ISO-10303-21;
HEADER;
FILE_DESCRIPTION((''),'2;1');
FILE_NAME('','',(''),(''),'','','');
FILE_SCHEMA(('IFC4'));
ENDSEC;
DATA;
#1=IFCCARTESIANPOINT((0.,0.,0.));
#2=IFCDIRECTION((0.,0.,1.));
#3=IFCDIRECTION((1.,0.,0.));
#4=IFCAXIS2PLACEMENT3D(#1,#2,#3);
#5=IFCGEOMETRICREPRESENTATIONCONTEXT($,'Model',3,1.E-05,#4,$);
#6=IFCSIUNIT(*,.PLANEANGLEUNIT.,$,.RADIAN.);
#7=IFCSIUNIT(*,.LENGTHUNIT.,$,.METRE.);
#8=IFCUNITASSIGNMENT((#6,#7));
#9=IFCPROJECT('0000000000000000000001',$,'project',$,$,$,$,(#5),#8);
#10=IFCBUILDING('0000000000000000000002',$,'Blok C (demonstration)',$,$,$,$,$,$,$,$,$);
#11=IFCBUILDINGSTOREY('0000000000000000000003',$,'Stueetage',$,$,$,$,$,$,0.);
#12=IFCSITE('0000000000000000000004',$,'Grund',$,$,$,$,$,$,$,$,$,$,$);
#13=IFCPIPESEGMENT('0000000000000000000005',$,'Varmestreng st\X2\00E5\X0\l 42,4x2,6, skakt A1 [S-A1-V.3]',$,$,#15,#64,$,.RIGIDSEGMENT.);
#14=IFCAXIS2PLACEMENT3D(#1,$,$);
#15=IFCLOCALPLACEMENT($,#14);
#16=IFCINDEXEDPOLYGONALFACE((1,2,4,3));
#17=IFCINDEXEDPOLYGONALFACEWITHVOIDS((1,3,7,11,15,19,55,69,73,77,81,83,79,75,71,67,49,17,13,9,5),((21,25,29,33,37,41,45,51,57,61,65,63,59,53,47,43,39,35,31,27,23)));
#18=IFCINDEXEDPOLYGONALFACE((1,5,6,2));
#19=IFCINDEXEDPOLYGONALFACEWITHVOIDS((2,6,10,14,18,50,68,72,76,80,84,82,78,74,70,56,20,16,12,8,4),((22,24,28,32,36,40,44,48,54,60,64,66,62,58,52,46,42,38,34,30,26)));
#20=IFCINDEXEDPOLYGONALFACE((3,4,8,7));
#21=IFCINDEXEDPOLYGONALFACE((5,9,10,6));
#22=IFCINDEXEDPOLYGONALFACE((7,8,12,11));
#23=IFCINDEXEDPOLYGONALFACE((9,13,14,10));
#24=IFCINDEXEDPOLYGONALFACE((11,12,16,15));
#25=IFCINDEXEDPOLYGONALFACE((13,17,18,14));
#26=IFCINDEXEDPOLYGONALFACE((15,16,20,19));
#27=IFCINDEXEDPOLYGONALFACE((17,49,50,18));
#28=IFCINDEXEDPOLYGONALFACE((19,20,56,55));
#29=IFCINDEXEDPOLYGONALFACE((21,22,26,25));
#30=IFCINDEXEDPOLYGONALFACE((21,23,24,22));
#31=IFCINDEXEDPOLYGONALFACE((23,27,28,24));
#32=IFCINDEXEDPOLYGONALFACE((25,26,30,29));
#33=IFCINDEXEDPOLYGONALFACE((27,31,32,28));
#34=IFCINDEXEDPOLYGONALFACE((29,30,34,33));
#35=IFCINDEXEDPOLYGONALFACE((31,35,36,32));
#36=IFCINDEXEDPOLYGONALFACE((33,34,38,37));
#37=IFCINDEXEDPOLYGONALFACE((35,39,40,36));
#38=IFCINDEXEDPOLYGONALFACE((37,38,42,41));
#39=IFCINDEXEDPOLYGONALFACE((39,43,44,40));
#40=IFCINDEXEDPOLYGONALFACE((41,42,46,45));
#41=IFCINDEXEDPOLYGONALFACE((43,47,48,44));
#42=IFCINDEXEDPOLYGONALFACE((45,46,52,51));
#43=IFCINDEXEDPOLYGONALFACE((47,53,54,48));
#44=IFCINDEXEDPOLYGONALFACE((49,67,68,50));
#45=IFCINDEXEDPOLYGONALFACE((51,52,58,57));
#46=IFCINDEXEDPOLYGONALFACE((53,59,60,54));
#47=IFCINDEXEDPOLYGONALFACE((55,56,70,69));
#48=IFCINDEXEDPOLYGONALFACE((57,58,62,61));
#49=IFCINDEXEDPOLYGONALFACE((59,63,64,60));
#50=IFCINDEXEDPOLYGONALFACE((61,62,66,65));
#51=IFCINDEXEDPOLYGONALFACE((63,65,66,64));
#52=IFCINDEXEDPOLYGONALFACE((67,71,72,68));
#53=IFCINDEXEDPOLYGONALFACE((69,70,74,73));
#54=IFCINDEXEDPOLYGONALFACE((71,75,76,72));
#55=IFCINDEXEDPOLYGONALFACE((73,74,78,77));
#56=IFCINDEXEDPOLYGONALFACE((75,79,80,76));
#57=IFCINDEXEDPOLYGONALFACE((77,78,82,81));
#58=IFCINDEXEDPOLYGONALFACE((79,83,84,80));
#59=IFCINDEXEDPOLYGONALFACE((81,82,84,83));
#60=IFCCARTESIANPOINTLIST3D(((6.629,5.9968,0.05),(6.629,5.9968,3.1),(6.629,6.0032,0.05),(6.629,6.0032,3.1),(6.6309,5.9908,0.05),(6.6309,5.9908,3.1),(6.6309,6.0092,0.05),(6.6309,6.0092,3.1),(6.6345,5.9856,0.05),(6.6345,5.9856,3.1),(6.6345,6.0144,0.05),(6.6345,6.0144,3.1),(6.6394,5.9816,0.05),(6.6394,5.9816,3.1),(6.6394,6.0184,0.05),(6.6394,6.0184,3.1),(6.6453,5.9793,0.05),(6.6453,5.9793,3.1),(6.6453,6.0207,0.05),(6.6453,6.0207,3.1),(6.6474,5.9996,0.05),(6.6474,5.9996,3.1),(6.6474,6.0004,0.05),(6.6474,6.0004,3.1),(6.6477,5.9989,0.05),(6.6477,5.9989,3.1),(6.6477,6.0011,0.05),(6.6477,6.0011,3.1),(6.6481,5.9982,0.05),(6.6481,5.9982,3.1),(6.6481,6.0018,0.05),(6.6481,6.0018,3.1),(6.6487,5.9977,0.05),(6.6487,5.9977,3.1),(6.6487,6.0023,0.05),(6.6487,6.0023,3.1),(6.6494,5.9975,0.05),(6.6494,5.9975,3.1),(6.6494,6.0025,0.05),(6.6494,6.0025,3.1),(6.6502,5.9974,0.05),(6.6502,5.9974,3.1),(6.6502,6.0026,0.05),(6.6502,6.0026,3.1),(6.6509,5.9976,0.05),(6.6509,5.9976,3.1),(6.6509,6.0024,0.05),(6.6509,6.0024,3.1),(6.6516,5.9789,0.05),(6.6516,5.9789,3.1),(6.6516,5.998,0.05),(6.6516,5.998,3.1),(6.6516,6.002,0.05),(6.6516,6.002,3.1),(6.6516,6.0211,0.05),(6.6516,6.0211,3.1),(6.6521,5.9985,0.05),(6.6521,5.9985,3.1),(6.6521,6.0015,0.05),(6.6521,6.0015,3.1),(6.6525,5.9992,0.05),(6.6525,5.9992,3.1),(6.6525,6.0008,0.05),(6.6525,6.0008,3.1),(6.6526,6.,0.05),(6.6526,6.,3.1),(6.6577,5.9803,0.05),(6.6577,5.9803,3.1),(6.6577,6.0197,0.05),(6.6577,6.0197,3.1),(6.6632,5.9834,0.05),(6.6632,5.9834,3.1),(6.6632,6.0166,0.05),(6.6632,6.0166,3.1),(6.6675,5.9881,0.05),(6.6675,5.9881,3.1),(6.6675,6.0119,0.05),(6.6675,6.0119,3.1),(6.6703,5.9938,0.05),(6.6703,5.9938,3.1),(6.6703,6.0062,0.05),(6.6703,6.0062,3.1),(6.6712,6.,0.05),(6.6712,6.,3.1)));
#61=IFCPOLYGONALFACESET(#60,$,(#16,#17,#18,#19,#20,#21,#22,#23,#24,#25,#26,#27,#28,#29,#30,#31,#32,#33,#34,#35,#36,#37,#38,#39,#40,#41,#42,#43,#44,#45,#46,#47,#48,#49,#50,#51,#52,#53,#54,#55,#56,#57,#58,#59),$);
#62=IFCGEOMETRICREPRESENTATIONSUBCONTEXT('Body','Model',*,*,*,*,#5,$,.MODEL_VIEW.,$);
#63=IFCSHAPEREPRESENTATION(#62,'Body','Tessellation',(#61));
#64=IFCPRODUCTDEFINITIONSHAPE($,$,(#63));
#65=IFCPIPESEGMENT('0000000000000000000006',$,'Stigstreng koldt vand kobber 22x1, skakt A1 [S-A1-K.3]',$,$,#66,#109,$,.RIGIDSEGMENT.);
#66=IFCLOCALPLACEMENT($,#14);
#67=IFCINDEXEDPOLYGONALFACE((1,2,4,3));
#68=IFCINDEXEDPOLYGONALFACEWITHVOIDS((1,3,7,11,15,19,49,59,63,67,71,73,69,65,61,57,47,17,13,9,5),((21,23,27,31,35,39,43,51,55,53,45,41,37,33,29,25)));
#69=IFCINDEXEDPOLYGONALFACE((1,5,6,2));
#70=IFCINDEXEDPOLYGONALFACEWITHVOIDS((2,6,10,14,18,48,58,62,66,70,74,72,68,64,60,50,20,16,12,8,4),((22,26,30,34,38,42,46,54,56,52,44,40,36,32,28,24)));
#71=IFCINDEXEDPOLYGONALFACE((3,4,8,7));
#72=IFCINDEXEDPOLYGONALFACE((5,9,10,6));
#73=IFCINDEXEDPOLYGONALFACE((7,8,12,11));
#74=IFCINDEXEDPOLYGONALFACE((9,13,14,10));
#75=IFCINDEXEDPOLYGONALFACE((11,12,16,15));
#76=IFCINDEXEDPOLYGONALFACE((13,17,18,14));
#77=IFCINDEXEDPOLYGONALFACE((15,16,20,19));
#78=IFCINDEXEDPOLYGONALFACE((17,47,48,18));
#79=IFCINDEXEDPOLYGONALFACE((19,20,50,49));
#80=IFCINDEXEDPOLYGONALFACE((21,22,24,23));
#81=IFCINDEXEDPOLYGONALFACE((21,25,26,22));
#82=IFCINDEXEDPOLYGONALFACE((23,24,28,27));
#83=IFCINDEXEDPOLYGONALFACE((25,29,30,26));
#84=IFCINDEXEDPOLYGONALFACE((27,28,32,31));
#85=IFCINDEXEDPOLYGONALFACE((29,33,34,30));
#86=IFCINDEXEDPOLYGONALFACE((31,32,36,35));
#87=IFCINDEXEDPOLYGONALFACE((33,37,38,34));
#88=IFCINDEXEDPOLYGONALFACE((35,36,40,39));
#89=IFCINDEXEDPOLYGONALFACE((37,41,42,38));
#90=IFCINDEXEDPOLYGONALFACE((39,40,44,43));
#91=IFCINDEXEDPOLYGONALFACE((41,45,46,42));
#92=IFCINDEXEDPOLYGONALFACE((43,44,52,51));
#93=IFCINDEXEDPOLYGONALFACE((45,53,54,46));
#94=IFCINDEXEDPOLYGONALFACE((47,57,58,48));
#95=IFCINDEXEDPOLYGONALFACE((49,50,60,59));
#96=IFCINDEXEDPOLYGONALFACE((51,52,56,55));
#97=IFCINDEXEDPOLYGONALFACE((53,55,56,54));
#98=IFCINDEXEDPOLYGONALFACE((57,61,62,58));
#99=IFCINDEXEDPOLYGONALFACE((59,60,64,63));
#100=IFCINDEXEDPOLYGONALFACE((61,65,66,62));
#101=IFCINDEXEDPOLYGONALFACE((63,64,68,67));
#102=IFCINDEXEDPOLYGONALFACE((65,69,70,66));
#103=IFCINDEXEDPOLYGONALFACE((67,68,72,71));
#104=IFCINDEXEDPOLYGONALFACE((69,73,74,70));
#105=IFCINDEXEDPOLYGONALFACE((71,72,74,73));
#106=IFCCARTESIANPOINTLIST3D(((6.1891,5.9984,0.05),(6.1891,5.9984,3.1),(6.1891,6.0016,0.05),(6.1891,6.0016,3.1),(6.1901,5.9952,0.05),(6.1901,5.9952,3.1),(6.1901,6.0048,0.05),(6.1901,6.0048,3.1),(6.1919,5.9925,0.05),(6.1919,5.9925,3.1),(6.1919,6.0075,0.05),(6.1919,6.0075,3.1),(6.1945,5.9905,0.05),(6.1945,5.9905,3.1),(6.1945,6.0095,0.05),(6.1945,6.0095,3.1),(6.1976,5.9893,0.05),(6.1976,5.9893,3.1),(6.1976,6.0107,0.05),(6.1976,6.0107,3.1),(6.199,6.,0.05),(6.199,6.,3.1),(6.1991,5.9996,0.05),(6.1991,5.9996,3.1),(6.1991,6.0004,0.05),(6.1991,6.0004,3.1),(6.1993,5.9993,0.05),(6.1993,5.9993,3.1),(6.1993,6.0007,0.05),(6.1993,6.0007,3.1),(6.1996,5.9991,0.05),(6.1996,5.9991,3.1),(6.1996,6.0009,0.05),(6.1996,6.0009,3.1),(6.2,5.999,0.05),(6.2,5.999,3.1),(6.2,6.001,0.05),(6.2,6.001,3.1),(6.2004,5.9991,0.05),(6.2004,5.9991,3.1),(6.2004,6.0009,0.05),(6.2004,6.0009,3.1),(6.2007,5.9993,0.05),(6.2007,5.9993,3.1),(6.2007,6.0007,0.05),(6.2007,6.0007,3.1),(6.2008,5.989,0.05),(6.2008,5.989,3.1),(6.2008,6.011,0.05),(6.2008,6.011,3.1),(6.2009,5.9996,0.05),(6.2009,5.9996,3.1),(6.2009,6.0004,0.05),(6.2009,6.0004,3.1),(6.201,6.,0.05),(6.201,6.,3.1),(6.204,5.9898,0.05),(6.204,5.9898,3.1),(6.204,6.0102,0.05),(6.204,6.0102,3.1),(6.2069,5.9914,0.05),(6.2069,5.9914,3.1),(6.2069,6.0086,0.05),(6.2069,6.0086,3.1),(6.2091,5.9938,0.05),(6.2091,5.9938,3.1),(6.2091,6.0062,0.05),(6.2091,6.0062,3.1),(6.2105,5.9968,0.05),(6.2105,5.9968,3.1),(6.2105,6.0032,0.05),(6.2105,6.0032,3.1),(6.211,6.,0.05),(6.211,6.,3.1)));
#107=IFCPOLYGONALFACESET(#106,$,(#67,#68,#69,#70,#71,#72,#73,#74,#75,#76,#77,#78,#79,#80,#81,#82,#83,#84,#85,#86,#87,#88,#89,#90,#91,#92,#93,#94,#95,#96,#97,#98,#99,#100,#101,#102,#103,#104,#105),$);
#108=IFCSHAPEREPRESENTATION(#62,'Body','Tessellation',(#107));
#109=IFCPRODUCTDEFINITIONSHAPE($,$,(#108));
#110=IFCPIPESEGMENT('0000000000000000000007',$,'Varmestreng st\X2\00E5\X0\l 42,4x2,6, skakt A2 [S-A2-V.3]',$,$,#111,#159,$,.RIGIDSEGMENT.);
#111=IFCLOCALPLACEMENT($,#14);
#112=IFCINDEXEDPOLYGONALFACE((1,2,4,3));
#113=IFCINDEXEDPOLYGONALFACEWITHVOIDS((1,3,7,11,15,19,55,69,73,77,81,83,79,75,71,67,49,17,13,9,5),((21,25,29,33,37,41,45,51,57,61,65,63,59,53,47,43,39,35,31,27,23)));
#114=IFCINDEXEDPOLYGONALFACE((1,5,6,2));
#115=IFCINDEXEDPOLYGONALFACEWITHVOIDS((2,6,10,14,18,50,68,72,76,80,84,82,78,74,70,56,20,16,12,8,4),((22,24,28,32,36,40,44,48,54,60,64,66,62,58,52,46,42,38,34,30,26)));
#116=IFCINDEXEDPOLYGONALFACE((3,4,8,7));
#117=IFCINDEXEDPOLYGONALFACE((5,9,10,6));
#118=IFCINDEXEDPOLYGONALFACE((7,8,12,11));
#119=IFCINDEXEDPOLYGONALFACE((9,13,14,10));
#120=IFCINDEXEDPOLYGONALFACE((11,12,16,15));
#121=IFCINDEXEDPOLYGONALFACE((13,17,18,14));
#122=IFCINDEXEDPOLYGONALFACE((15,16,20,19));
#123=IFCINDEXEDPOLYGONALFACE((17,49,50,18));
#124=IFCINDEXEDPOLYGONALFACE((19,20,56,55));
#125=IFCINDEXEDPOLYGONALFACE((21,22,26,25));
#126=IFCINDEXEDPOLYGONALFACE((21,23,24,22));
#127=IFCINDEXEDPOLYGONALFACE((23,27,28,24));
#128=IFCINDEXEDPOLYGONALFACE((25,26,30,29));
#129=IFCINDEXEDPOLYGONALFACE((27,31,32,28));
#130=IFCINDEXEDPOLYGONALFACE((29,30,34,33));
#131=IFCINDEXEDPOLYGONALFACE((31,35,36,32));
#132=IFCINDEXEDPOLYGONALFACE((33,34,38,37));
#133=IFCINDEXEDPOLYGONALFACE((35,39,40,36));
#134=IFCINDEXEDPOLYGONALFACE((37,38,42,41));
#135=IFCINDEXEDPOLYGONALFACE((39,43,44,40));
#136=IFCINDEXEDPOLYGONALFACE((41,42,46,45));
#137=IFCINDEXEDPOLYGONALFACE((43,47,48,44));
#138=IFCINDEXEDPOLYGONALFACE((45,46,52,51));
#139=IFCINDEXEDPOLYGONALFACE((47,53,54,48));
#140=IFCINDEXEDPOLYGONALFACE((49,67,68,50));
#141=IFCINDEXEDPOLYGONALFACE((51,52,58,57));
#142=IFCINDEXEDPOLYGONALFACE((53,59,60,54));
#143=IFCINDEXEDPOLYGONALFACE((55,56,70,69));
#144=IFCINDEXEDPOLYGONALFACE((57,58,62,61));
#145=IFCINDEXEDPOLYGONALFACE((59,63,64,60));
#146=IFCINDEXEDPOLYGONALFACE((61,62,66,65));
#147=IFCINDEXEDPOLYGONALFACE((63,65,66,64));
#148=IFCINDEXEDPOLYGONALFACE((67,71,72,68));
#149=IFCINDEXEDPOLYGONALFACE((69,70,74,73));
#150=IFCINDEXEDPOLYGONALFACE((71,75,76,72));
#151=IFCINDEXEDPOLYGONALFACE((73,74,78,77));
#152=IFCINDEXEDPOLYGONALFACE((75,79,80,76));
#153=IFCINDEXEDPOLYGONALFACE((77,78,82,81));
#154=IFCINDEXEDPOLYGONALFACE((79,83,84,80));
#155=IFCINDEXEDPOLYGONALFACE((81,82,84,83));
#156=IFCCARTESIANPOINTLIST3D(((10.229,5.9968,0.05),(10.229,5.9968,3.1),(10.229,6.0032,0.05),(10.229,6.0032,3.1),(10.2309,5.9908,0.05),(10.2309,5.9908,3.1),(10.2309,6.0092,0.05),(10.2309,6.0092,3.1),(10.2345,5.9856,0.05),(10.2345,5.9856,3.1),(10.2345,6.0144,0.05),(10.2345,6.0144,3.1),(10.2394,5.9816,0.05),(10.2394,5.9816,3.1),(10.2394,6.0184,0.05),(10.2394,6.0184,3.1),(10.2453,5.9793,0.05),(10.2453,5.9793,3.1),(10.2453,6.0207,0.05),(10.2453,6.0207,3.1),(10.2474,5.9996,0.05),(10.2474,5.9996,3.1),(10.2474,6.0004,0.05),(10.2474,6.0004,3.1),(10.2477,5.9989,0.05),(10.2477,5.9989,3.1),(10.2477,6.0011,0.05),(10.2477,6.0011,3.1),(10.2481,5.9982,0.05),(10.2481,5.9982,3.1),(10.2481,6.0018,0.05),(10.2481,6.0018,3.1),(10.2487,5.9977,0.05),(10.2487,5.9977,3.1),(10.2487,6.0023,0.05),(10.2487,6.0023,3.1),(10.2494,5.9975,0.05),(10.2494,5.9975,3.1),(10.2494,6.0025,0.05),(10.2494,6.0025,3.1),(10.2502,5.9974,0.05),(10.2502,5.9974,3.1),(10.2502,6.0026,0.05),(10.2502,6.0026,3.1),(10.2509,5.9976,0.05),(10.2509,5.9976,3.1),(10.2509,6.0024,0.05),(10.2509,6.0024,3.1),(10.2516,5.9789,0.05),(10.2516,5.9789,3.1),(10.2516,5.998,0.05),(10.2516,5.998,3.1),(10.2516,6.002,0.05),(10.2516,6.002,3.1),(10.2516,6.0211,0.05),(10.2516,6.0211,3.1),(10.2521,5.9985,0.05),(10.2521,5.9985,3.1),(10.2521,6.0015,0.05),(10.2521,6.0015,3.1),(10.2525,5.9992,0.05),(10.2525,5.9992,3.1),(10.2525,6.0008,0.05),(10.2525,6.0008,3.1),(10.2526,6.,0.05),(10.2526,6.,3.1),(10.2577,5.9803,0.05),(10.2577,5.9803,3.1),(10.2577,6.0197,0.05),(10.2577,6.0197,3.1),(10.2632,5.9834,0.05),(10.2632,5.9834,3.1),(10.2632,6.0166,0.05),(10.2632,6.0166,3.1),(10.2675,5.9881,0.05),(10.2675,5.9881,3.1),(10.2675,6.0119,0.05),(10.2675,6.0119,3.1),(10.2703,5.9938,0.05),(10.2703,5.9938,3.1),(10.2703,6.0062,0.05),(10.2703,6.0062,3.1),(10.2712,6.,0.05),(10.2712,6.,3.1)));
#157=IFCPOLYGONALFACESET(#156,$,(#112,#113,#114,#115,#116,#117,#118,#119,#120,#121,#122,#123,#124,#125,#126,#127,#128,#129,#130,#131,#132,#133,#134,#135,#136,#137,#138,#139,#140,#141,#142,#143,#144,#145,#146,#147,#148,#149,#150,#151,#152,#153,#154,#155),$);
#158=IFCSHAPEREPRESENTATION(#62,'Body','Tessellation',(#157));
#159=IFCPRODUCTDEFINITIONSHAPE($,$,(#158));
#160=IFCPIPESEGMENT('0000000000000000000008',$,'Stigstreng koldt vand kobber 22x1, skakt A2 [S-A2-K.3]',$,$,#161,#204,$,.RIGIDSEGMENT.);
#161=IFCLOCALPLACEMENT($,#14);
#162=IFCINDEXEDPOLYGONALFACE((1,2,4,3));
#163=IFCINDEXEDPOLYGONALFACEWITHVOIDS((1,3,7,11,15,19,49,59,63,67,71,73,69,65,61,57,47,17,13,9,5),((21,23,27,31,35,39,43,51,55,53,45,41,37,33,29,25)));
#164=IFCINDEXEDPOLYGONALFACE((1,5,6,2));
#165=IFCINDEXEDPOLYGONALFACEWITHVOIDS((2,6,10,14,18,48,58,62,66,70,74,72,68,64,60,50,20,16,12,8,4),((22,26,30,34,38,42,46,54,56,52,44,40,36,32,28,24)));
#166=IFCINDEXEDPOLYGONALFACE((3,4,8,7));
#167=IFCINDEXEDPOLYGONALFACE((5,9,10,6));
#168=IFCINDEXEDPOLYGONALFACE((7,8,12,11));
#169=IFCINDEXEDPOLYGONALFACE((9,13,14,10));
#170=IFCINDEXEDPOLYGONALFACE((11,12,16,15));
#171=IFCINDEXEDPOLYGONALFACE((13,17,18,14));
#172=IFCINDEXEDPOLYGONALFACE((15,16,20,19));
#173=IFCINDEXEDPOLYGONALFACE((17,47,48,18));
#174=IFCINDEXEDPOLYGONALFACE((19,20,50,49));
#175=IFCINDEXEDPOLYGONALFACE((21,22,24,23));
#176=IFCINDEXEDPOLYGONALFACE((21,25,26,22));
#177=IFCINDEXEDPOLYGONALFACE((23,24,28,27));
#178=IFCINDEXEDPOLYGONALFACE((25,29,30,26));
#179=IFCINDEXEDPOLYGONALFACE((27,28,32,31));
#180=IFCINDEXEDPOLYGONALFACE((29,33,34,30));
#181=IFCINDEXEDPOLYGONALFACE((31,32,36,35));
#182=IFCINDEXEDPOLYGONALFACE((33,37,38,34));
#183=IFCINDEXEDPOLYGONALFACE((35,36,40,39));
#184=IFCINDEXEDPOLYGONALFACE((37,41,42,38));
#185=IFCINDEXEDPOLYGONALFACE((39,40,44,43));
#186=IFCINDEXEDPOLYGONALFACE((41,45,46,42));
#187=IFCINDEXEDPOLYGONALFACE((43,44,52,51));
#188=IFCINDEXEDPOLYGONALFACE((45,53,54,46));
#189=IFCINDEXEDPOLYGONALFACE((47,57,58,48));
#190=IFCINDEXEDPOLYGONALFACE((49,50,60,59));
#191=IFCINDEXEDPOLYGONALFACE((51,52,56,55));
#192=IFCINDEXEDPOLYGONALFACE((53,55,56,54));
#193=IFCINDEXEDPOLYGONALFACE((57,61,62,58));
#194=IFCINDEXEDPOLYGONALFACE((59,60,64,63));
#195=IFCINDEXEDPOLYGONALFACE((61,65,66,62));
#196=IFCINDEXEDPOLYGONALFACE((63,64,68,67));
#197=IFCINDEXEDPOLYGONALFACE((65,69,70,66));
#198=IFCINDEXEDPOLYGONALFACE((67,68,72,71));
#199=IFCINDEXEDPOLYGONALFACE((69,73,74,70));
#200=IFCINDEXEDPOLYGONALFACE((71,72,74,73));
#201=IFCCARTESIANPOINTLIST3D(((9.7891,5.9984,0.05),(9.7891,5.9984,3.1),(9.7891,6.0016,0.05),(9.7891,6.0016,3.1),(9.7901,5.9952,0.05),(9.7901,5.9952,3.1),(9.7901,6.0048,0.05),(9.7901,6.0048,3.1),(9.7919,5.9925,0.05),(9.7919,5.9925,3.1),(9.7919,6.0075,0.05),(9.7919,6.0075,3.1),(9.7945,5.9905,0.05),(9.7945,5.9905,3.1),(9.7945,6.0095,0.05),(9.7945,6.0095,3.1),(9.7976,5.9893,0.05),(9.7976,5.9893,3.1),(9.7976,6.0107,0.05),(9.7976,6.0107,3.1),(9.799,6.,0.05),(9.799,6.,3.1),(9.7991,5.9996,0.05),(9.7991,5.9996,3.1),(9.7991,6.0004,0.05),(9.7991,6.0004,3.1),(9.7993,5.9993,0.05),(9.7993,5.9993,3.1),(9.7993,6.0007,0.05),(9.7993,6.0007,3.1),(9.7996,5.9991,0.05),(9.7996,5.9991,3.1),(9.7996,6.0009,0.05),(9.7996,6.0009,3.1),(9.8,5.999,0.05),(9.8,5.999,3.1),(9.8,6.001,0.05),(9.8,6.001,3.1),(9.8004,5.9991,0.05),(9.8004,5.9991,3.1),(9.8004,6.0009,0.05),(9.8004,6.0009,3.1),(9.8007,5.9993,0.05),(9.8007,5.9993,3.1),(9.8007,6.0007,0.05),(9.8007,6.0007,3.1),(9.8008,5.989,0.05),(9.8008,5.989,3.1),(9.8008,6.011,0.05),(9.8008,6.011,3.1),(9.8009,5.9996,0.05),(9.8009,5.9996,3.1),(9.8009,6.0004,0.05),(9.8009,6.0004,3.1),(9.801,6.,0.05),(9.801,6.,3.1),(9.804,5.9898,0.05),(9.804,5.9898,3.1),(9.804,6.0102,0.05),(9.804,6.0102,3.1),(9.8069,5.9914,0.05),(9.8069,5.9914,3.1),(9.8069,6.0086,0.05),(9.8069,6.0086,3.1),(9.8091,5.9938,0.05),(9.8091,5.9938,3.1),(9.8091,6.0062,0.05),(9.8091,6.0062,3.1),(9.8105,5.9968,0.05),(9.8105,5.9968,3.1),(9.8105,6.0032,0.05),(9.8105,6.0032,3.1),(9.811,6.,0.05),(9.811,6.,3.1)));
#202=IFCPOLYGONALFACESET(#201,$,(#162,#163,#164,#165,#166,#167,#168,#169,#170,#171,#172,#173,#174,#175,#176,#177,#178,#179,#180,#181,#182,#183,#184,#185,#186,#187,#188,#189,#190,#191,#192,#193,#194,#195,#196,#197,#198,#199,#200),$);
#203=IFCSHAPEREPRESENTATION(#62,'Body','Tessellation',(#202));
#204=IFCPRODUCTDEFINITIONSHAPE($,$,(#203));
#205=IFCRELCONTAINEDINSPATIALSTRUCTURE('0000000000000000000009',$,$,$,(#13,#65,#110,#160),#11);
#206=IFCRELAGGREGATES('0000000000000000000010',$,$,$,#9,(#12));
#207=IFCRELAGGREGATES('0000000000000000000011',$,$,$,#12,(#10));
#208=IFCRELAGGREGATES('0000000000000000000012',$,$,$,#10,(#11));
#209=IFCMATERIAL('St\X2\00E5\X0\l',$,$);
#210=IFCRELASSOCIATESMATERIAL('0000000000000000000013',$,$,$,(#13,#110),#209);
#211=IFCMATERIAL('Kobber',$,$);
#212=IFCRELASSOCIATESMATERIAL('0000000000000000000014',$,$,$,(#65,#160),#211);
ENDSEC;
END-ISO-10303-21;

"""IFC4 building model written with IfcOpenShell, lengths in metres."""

from ifc_helpers import new_model, si_unit, frame, origin_with_axes, place, context, subcontext, project, spatial, hollow_circle, extrude, material, element, save


model = new_model("IFC4")

# Units and contexts
model_context = context("Model", 3, precision=1e-05, world=origin_with_axes())
body_context = subcontext(model_context, "Body", "Model", "MODEL_VIEW")
ifc_project = project(units=[si_unit("PLANEANGLEUNIT", "RADIAN"), si_unit("LENGTHUNIT", "METRE")], contexts=[model_context])

# Site, building, storey
site = spatial("IfcSite", under=ifc_project, Name="Grund")
building = spatial("IfcBuilding", under=site, Name="Blok C (demonstration)")
storey = spatial("IfcBuildingStorey", under=building, Name="Stueetage", Elevation=0.0)

# Pipe segments
ifc_material_1 = material(Name="Stål")
pipe_segment_1_placement = place(None, origin_with_axes())
element("IfcPipeSegment", 1, at=pipe_segment_1_placement, inside=storey, material=ifc_material_1, Name="Varmestreng stål 42,4x2,6, skakt A1 [S-A1-V.3]", PredefinedType="RIGIDSEGMENT", context=body_context, shape_type="SweptSolid", body=[
    extrude(hollow_circle(Radius=0.0212, WallThickness=0.0186), frame((6.65, 6.0, 0.05), z_axis=(0.0, 0.0, 1.0), x_axis=(1.0, 0.0, 0.0)), (0.0, 0.0, 1.0), 3.05),
])
ifc_material_2 = material(Name="Kobber")
pipe_segment_2_placement = place(None, origin_with_axes())
element("IfcPipeSegment", 2, at=pipe_segment_2_placement, inside=storey, material=ifc_material_2, Name="Stigstreng koldt vand kobber 22x1, skakt A1 [S-A1-K.3]", PredefinedType="RIGIDSEGMENT", context=body_context, shape_type="SweptSolid", body=[
    extrude(hollow_circle(Radius=0.011, WallThickness=0.01), frame((6.2, 6.0, 0.05), z_axis=(0.0, 0.0, 1.0), x_axis=(1.0, 0.0, 0.0)), (0.0, 0.0, 1.0), 3.05),
])
pipe_segment_3_placement = place(None, origin_with_axes())
element("IfcPipeSegment", 3, at=pipe_segment_3_placement, inside=storey, material=ifc_material_1, Name="Varmestreng stål 42,4x2,6, skakt A2 [S-A2-V.3]", PredefinedType="RIGIDSEGMENT", context=body_context, shape_type="SweptSolid", body=[
    extrude(hollow_circle(Radius=0.0212, WallThickness=0.0186), frame((10.25, 6.0, 0.05), z_axis=(0.0, 0.0, 1.0), x_axis=(1.0, 0.0, 0.0)), (0.0, 0.0, 1.0), 3.05),
])
pipe_segment_4_placement = place(None, origin_with_axes())
element("IfcPipeSegment", 4, at=pipe_segment_4_placement, inside=storey, material=ifc_material_2, Name="Stigstreng koldt vand kobber 22x1, skakt A2 [S-A2-K.3]", PredefinedType="RIGIDSEGMENT", context=body_context, shape_type="SweptSolid", body=[
    extrude(hollow_circle(Radius=0.011, WallThickness=0.01), frame((9.8, 6.0, 0.05), z_axis=(0.0, 0.0, 1.0), x_axis=(1.0, 0.0, 0.0)), (0.0, 0.0, 1.0), 3.05),
])

save(model, "model.ifc")
